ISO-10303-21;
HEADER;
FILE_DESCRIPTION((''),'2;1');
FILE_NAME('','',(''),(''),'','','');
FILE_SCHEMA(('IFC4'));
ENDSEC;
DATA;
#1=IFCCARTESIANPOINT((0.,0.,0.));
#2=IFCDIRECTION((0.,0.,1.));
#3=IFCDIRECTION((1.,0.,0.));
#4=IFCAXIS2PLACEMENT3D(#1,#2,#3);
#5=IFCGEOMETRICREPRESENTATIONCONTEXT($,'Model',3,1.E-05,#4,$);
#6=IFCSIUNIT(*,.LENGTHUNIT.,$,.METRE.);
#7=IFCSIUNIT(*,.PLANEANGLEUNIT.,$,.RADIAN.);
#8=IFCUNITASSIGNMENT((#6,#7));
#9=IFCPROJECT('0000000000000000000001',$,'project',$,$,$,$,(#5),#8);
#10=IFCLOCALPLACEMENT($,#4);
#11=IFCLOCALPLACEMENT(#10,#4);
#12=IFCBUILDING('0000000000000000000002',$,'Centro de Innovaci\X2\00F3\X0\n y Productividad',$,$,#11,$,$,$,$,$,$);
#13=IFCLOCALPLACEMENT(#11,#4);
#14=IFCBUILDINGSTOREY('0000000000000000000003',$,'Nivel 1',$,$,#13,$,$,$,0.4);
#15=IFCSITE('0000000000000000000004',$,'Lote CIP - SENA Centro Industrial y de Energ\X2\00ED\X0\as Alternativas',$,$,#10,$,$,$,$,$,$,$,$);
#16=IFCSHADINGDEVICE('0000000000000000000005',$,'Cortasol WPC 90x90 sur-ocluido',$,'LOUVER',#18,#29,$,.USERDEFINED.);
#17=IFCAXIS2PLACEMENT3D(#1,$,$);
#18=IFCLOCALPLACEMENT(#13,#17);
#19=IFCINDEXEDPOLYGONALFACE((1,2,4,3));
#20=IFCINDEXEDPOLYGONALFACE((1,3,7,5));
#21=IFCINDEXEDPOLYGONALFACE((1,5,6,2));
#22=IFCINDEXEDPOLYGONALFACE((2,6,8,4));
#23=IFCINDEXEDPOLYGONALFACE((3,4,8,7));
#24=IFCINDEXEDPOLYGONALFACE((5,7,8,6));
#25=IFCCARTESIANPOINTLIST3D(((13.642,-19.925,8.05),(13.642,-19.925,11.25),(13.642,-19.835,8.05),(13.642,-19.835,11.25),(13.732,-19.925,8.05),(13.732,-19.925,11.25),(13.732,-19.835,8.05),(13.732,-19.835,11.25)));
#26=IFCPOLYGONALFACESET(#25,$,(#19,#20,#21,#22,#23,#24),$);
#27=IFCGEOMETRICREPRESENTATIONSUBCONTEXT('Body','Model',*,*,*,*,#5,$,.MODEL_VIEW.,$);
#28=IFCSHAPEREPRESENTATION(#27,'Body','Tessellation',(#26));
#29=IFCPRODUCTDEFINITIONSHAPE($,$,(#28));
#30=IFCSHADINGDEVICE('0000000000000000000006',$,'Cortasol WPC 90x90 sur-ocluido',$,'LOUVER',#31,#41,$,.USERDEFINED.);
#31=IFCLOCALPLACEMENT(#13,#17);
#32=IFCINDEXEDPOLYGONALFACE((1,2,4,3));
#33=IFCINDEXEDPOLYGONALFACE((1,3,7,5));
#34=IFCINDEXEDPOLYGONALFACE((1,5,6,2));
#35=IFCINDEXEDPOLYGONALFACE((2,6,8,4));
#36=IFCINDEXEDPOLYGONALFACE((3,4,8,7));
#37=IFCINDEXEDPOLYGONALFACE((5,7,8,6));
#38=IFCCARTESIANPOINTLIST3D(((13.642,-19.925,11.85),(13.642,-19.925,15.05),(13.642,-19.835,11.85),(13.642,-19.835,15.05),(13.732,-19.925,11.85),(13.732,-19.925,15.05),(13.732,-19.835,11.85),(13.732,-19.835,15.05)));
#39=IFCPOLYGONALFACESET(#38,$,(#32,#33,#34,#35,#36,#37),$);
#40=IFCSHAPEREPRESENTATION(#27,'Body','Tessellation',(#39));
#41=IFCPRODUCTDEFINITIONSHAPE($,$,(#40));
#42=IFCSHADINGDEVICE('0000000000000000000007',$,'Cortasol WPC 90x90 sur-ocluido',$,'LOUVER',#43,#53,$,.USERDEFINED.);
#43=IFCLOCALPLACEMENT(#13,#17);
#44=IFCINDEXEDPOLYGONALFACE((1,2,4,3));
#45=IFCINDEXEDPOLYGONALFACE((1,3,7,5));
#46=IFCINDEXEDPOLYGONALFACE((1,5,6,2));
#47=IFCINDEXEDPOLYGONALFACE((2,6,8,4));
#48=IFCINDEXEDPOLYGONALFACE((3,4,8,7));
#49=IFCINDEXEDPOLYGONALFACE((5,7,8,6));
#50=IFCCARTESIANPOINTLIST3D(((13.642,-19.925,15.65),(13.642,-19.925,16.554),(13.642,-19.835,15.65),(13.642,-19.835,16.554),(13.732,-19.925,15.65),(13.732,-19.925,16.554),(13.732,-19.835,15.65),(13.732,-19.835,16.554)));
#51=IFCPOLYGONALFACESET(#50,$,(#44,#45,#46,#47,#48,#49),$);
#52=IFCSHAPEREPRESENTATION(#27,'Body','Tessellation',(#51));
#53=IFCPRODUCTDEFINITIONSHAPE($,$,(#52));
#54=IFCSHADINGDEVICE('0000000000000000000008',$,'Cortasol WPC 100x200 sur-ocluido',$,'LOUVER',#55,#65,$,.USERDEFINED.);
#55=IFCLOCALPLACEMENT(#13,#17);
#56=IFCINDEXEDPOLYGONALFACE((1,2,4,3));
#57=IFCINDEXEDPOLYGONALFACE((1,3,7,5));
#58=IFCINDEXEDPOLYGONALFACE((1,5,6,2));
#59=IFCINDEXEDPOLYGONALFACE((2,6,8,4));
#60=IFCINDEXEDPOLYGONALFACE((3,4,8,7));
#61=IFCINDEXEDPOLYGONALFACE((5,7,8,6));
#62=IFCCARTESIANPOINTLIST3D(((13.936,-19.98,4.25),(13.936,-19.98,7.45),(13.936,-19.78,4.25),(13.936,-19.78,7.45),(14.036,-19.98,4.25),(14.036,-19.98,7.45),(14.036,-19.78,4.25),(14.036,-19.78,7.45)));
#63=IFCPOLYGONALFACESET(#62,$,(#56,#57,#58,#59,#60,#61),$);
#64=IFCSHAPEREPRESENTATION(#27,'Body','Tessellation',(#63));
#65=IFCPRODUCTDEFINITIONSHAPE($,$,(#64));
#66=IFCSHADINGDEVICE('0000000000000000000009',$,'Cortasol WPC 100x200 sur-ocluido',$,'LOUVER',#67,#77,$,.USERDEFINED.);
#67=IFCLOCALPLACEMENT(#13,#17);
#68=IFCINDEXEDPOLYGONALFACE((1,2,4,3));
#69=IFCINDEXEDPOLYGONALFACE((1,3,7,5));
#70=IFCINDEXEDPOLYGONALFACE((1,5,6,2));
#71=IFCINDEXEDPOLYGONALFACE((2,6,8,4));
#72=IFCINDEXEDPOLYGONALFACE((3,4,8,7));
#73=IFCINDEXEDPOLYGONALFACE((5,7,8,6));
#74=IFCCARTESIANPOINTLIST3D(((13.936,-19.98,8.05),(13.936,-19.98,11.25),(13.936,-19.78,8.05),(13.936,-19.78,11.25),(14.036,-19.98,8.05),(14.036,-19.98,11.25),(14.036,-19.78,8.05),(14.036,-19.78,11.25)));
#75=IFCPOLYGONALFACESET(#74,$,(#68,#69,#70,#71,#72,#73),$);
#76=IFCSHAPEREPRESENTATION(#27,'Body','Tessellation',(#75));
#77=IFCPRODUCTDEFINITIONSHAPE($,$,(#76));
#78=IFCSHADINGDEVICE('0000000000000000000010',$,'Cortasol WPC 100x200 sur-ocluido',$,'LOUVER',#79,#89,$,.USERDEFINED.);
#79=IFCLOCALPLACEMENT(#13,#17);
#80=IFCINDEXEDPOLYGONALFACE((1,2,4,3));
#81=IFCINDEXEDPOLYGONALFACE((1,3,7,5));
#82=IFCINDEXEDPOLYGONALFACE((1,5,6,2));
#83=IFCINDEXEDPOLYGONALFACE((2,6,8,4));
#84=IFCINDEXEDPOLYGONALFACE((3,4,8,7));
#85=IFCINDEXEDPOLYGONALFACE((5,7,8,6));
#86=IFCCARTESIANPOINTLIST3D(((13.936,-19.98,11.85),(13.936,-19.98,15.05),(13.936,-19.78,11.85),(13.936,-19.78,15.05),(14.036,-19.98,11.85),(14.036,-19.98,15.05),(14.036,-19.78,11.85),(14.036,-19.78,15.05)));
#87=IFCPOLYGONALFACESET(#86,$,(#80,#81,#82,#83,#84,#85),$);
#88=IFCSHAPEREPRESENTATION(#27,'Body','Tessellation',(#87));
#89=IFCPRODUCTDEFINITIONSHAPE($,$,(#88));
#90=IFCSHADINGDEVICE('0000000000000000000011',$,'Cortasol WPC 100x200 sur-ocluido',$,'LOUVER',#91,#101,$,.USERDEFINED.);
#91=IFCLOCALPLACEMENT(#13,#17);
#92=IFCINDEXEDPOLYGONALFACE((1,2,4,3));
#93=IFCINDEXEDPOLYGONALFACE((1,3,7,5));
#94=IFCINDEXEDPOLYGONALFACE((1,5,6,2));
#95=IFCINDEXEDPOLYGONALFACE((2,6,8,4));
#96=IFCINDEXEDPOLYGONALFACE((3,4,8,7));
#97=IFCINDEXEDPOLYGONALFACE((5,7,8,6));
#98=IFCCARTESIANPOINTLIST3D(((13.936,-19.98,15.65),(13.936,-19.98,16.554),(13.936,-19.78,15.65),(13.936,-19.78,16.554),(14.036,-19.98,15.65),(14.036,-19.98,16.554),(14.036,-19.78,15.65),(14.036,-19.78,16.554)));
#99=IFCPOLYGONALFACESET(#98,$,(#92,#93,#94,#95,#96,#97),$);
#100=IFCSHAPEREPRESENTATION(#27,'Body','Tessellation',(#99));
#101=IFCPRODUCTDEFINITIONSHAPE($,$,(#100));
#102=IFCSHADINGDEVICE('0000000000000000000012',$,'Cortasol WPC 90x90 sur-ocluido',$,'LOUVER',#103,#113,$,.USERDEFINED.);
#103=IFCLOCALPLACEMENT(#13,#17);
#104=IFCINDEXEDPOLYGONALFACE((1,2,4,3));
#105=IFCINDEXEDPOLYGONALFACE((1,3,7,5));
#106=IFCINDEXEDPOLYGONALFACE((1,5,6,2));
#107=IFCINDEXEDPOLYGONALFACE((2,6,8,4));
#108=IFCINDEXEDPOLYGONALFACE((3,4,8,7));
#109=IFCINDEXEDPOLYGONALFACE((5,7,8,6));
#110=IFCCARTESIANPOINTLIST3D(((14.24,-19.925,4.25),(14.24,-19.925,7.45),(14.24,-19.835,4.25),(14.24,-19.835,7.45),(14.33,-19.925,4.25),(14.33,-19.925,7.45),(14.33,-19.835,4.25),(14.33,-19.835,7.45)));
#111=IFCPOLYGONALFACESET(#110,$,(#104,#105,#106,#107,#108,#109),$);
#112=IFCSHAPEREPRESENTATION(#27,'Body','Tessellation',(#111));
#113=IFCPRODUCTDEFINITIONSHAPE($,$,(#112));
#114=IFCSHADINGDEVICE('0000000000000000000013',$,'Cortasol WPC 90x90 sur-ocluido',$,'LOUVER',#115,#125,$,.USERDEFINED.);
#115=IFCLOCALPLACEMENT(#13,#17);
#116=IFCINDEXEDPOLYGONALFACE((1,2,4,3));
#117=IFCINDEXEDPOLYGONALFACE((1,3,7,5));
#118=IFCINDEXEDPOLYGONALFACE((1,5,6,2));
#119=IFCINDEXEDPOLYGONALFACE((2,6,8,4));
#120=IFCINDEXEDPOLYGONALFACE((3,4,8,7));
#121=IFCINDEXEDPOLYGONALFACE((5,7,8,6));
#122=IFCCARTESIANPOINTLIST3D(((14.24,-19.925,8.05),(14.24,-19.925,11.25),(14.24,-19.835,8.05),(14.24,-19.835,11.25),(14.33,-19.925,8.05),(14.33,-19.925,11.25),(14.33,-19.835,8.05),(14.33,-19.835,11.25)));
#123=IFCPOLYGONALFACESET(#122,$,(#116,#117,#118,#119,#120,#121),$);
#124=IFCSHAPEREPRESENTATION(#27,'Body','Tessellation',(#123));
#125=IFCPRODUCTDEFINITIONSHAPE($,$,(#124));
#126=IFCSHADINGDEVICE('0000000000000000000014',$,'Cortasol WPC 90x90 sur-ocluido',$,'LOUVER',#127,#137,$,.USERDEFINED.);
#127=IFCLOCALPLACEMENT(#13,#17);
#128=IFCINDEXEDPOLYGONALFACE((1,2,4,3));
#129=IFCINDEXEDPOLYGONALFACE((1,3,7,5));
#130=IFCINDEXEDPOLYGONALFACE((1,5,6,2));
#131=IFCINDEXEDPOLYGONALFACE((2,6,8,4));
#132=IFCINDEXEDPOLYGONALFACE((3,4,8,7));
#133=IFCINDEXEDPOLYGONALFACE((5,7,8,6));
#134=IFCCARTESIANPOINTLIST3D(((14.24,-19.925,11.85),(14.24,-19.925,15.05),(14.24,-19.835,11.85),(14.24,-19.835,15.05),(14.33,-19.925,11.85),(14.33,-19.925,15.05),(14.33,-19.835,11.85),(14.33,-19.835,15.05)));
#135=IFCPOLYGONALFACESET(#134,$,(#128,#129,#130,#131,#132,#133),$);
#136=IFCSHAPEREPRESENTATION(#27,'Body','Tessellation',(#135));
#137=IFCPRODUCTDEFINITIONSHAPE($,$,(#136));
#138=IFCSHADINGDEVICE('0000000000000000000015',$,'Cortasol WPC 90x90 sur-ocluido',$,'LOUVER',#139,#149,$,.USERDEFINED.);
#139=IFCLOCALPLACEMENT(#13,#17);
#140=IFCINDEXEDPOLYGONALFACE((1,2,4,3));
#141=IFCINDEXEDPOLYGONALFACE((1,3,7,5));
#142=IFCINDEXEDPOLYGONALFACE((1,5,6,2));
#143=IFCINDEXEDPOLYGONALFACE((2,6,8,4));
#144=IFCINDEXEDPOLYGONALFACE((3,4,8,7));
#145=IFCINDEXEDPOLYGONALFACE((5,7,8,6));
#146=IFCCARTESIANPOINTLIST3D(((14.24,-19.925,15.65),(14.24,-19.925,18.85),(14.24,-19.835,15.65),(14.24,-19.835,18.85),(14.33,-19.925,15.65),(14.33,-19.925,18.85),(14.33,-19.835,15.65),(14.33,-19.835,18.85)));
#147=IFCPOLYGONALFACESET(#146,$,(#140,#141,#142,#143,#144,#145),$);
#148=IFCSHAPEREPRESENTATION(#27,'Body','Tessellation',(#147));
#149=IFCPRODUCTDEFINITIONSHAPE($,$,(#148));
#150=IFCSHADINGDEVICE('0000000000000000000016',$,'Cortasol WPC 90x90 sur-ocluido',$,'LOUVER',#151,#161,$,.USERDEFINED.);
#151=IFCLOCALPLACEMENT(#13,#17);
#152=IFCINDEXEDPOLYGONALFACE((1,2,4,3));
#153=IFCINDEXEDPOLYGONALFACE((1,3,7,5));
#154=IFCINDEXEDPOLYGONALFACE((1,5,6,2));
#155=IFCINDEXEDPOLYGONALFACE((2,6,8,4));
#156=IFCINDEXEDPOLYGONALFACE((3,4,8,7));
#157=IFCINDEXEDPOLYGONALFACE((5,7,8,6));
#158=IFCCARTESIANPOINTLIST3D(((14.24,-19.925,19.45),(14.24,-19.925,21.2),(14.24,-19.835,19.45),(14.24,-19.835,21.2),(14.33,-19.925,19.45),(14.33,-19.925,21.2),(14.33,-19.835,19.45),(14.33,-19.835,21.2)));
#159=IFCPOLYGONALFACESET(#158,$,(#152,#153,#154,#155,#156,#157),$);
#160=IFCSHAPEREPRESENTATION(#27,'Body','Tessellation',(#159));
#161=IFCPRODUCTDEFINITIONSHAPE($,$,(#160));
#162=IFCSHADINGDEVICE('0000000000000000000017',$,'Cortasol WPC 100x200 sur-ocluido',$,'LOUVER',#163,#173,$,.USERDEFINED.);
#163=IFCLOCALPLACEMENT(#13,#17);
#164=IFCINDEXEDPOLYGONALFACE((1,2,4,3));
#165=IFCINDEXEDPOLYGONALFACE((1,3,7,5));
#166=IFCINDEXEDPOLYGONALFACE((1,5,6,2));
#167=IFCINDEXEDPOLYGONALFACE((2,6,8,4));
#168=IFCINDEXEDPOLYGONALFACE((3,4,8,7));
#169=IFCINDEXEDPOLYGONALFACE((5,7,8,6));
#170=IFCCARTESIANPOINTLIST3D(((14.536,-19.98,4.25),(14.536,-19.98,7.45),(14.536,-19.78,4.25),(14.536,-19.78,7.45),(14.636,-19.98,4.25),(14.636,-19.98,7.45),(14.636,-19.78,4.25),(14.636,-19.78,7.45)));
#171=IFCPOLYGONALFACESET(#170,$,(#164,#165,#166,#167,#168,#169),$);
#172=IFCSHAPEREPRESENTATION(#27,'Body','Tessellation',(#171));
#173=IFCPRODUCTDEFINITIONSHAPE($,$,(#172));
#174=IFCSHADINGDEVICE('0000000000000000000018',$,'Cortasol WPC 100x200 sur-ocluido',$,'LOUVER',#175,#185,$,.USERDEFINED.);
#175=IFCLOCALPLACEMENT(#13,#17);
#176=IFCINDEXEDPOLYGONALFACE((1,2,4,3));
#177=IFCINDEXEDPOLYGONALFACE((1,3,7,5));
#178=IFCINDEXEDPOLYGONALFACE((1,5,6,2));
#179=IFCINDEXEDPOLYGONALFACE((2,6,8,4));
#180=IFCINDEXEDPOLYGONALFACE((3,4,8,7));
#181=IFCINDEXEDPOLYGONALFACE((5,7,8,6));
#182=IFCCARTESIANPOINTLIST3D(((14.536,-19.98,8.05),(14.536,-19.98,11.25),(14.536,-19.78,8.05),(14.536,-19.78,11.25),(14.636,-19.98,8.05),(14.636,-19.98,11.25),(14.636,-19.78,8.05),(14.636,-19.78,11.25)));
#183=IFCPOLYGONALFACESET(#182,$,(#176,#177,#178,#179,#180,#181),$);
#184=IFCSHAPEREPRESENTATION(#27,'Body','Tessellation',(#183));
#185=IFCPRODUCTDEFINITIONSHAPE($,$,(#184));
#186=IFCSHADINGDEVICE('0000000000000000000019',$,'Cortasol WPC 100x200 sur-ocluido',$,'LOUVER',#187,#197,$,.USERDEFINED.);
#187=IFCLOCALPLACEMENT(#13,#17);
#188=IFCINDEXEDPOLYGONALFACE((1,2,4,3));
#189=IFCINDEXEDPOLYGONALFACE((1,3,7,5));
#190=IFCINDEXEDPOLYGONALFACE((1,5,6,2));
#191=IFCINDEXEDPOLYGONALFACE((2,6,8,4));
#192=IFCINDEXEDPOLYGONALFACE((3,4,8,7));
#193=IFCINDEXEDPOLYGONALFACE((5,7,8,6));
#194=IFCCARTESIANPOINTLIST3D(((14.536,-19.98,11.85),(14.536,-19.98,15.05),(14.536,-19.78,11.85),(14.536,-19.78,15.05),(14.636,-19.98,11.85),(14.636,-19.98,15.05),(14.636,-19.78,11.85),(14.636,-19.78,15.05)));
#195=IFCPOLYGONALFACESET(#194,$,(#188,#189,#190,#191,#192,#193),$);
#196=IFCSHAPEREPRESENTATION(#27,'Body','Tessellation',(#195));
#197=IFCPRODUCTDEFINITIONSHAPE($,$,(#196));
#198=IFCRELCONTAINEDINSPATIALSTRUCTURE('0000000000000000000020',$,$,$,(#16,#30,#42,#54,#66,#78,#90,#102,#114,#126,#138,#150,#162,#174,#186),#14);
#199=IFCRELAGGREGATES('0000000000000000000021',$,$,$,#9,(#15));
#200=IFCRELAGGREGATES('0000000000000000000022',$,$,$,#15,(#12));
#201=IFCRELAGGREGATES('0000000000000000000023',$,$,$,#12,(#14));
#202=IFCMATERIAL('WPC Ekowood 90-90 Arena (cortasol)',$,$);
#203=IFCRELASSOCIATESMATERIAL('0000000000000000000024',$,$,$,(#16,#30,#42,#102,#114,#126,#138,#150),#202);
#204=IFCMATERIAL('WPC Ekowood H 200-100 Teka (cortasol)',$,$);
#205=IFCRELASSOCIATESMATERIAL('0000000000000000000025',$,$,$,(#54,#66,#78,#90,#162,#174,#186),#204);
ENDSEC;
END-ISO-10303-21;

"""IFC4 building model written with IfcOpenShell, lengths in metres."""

from ifc_helpers import new_model, si_unit, frame, origin_with_axes, place, context, subcontext, project, spatial, polyline, outline, extrude, material, element, save


model = new_model("IFC4")

# Units and contexts
model_context = context("Model", 3, precision=1e-05, world=origin_with_axes())
body_context = subcontext(model_context, "Body", "Model", "MODEL_VIEW")
ifc_project = project(units=[si_unit("LENGTHUNIT", "METRE"), si_unit("PLANEANGLEUNIT", "RADIAN")], contexts=[model_context])

# Site, building, storey
site_placement = place(None, origin_with_axes())
site = spatial("IfcSite", under=ifc_project, at=site_placement, Name="Lote CIP - SENA Centro Industrial y de Energías Alternativas")
building_placement = place(site_placement, origin_with_axes())
building = spatial("IfcBuilding", under=site, at=building_placement, Name="Centro de Innovación y Productividad")
storey_placement = place(building_placement, origin_with_axes())
storey = spatial("IfcBuildingStorey", under=building, at=storey_placement, Name="Nivel 1", Elevation=0.4)

# Shading devices
ifc_material_1 = material(Name="WPC Ekowood 90-90 Arena (cortasol)")
shading_device_1_placement = place(storey_placement, origin_with_axes())
element("IfcShadingDevice", 1, at=shading_device_1_placement, inside=storey, material=ifc_material_1, Name="Cortasol WPC 90x90 sur-ocluido", ObjectType="LOUVER", PredefinedType="USERDEFINED", context=body_context, shape_type="SweptSolid", body=[
    extrude(outline(polyline([(13.642, -19.925), (13.642, -19.835), (13.732, -19.835), (13.732, -19.925), (13.642, -19.925)])), frame((0.0, 0.0, 8.05)), (0.0, 0.0, 1.0), 3.2),
])
shading_device_2_placement = place(storey_placement, origin_with_axes())
element("IfcShadingDevice", 2, at=shading_device_2_placement, inside=storey, material=ifc_material_1, Name="Cortasol WPC 90x90 sur-ocluido", ObjectType="LOUVER", PredefinedType="USERDEFINED", context=body_context, shape_type="SweptSolid", body=[
    extrude(outline(polyline([(13.642, -19.925), (13.642, -19.835), (13.732, -19.835), (13.732, -19.925), (13.642, -19.925)])), frame((0.0, 0.0, 11.85)), (0.0, 0.0, 1.0), 3.2),
])
shading_device_3_placement = place(storey_placement, origin_with_axes())
element("IfcShadingDevice", 3, at=shading_device_3_placement, inside=storey, material=ifc_material_1, Name="Cortasol WPC 90x90 sur-ocluido", ObjectType="LOUVER", PredefinedType="USERDEFINED", context=body_context, shape_type="SweptSolid", body=[
    extrude(outline(polyline([(13.642, -19.925), (13.642, -19.835), (13.732, -19.835), (13.732, -19.925), (13.642, -19.925)])), frame((0.0, 0.0, 15.65)), (0.0, 0.0, 1.0), 0.904),
])
ifc_material_2 = material(Name="WPC Ekowood H 200-100 Teka (cortasol)")
shading_device_4_placement = place(storey_placement, origin_with_axes())
element("IfcShadingDevice", 4, at=shading_device_4_placement, inside=storey, material=ifc_material_2, Name="Cortasol WPC 100x200 sur-ocluido", ObjectType="LOUVER", PredefinedType="USERDEFINED", context=body_context, shape_type="SweptSolid", body=[
    extrude(outline(polyline([(13.936, -19.98), (13.936, -19.78), (14.036, -19.78), (14.036, -19.98), (13.936, -19.98)])), frame((0.0, 0.0, 4.25)), (0.0, 0.0, 1.0), 3.2),
])
shading_device_5_placement = place(storey_placement, origin_with_axes())
element("IfcShadingDevice", 5, at=shading_device_5_placement, inside=storey, material=ifc_material_2, Name="Cortasol WPC 100x200 sur-ocluido", ObjectType="LOUVER", PredefinedType="USERDEFINED", context=body_context, shape_type="SweptSolid", body=[
    extrude(outline(polyline([(13.936, -19.98), (13.936, -19.78), (14.036, -19.78), (14.036, -19.98), (13.936, -19.98)])), frame((0.0, 0.0, 8.05)), (0.0, 0.0, 1.0), 3.2),
])
shading_device_6_placement = place(storey_placement, origin_with_axes())
element("IfcShadingDevice", 6, at=shading_device_6_placement, inside=storey, material=ifc_material_2, Name="Cortasol WPC 100x200 sur-ocluido", ObjectType="LOUVER", PredefinedType="USERDEFINED", context=body_context, shape_type="SweptSolid", body=[
    extrude(outline(polyline([(13.936, -19.98), (13.936, -19.78), (14.036, -19.78), (14.036, -19.98), (13.936, -19.98)])), frame((0.0, 0.0, 11.85)), (0.0, 0.0, 1.0), 3.2),
])
shading_device_7_placement = place(storey_placement, origin_with_axes())
element("IfcShadingDevice", 7, at=shading_device_7_placement, inside=storey, material=ifc_material_2, Name="Cortasol WPC 100x200 sur-ocluido", ObjectType="LOUVER", PredefinedType="USERDEFINED", context=body_context, shape_type="SweptSolid", body=[
    extrude(outline(polyline([(13.936, -19.98), (13.936, -19.78), (14.036, -19.78), (14.036, -19.98), (13.936, -19.98)])), frame((0.0, 0.0, 15.65)), (0.0, 0.0, 1.0), 0.904),
])
shading_device_8_placement = place(storey_placement, origin_with_axes())
element("IfcShadingDevice", 8, at=shading_device_8_placement, inside=storey, material=ifc_material_1, Name="Cortasol WPC 90x90 sur-ocluido", ObjectType="LOUVER", PredefinedType="USERDEFINED", context=body_context, shape_type="SweptSolid", body=[
    extrude(outline(polyline([(14.24, -19.925), (14.24, -19.835), (14.33, -19.835), (14.33, -19.925), (14.24, -19.925)])), frame((0.0, 0.0, 4.25)), (0.0, 0.0, 1.0), 3.2),
])
shading_device_9_placement = place(storey_placement, origin_with_axes())
element("IfcShadingDevice", 9, at=shading_device_9_placement, inside=storey, material=ifc_material_1, Name="Cortasol WPC 90x90 sur-ocluido", ObjectType="LOUVER", PredefinedType="USERDEFINED", context=body_context, shape_type="SweptSolid", body=[
    extrude(outline(polyline([(14.24, -19.925), (14.24, -19.835), (14.33, -19.835), (14.33, -19.925), (14.24, -19.925)])), frame((0.0, 0.0, 8.05)), (0.0, 0.0, 1.0), 3.2),
])
shading_device_10_placement = place(storey_placement, origin_with_axes())
element("IfcShadingDevice", 10, at=shading_device_10_placement, inside=storey, material=ifc_material_1, Name="Cortasol WPC 90x90 sur-ocluido", ObjectType="LOUVER", PredefinedType="USERDEFINED", context=body_context, shape_type="SweptSolid", body=[
    extrude(outline(polyline([(14.24, -19.925), (14.24, -19.835), (14.33, -19.835), (14.33, -19.925), (14.24, -19.925)])), frame((0.0, 0.0, 11.85)), (0.0, 0.0, 1.0), 3.2),
])
shading_device_11_placement = place(storey_placement, origin_with_axes())
element("IfcShadingDevice", 11, at=shading_device_11_placement, inside=storey, material=ifc_material_1, Name="Cortasol WPC 90x90 sur-ocluido", ObjectType="LOUVER", PredefinedType="USERDEFINED", context=body_context, shape_type="SweptSolid", body=[
    extrude(outline(polyline([(14.24, -19.925), (14.24, -19.835), (14.33, -19.835), (14.33, -19.925), (14.24, -19.925)])), frame((0.0, 0.0, 15.65)), (0.0, 0.0, 1.0), 3.2),
])
shading_device_12_placement = place(storey_placement, origin_with_axes())
element("IfcShadingDevice", 12, at=shading_device_12_placement, inside=storey, material=ifc_material_1, Name="Cortasol WPC 90x90 sur-ocluido", ObjectType="LOUVER", PredefinedType="USERDEFINED", context=body_context, shape_type="SweptSolid", body=[
    extrude(outline(polyline([(14.24, -19.925), (14.24, -19.835), (14.33, -19.835), (14.33, -19.925), (14.24, -19.925)])), frame((0.0, 0.0, 19.45)), (0.0, 0.0, 1.0), 1.75),
])
shading_device_13_placement = place(storey_placement, origin_with_axes())
element("IfcShadingDevice", 13, at=shading_device_13_placement, inside=storey, material=ifc_material_2, Name="Cortasol WPC 100x200 sur-ocluido", ObjectType="LOUVER", PredefinedType="USERDEFINED", context=body_context, shape_type="SweptSolid", body=[
    extrude(outline(polyline([(14.536, -19.98), (14.536, -19.78), (14.636, -19.78), (14.636, -19.98), (14.536, -19.98)])), frame((0.0, 0.0, 4.25)), (0.0, 0.0, 1.0), 3.2),
])
shading_device_14_placement = place(storey_placement, origin_with_axes())
element("IfcShadingDevice", 14, at=shading_device_14_placement, inside=storey, material=ifc_material_2, Name="Cortasol WPC 100x200 sur-ocluido", ObjectType="LOUVER", PredefinedType="USERDEFINED", context=body_context, shape_type="SweptSolid", body=[
    extrude(outline(polyline([(14.536, -19.98), (14.536, -19.78), (14.636, -19.78), (14.636, -19.98), (14.536, -19.98)])), frame((0.0, 0.0, 8.05)), (0.0, 0.0, 1.0), 3.2),
])
shading_device_15_placement = place(storey_placement, origin_with_axes())
element("IfcShadingDevice", 15, at=shading_device_15_placement, inside=storey, material=ifc_material_2, Name="Cortasol WPC 100x200 sur-ocluido", ObjectType="LOUVER", PredefinedType="USERDEFINED", context=body_context, shape_type="SweptSolid", body=[
    extrude(outline(polyline([(14.536, -19.98), (14.536, -19.78), (14.636, -19.78), (14.636, -19.98), (14.536, -19.98)])), frame((0.0, 0.0, 11.85)), (0.0, 0.0, 1.0), 3.2),
])

save(model, "model.ifc")
